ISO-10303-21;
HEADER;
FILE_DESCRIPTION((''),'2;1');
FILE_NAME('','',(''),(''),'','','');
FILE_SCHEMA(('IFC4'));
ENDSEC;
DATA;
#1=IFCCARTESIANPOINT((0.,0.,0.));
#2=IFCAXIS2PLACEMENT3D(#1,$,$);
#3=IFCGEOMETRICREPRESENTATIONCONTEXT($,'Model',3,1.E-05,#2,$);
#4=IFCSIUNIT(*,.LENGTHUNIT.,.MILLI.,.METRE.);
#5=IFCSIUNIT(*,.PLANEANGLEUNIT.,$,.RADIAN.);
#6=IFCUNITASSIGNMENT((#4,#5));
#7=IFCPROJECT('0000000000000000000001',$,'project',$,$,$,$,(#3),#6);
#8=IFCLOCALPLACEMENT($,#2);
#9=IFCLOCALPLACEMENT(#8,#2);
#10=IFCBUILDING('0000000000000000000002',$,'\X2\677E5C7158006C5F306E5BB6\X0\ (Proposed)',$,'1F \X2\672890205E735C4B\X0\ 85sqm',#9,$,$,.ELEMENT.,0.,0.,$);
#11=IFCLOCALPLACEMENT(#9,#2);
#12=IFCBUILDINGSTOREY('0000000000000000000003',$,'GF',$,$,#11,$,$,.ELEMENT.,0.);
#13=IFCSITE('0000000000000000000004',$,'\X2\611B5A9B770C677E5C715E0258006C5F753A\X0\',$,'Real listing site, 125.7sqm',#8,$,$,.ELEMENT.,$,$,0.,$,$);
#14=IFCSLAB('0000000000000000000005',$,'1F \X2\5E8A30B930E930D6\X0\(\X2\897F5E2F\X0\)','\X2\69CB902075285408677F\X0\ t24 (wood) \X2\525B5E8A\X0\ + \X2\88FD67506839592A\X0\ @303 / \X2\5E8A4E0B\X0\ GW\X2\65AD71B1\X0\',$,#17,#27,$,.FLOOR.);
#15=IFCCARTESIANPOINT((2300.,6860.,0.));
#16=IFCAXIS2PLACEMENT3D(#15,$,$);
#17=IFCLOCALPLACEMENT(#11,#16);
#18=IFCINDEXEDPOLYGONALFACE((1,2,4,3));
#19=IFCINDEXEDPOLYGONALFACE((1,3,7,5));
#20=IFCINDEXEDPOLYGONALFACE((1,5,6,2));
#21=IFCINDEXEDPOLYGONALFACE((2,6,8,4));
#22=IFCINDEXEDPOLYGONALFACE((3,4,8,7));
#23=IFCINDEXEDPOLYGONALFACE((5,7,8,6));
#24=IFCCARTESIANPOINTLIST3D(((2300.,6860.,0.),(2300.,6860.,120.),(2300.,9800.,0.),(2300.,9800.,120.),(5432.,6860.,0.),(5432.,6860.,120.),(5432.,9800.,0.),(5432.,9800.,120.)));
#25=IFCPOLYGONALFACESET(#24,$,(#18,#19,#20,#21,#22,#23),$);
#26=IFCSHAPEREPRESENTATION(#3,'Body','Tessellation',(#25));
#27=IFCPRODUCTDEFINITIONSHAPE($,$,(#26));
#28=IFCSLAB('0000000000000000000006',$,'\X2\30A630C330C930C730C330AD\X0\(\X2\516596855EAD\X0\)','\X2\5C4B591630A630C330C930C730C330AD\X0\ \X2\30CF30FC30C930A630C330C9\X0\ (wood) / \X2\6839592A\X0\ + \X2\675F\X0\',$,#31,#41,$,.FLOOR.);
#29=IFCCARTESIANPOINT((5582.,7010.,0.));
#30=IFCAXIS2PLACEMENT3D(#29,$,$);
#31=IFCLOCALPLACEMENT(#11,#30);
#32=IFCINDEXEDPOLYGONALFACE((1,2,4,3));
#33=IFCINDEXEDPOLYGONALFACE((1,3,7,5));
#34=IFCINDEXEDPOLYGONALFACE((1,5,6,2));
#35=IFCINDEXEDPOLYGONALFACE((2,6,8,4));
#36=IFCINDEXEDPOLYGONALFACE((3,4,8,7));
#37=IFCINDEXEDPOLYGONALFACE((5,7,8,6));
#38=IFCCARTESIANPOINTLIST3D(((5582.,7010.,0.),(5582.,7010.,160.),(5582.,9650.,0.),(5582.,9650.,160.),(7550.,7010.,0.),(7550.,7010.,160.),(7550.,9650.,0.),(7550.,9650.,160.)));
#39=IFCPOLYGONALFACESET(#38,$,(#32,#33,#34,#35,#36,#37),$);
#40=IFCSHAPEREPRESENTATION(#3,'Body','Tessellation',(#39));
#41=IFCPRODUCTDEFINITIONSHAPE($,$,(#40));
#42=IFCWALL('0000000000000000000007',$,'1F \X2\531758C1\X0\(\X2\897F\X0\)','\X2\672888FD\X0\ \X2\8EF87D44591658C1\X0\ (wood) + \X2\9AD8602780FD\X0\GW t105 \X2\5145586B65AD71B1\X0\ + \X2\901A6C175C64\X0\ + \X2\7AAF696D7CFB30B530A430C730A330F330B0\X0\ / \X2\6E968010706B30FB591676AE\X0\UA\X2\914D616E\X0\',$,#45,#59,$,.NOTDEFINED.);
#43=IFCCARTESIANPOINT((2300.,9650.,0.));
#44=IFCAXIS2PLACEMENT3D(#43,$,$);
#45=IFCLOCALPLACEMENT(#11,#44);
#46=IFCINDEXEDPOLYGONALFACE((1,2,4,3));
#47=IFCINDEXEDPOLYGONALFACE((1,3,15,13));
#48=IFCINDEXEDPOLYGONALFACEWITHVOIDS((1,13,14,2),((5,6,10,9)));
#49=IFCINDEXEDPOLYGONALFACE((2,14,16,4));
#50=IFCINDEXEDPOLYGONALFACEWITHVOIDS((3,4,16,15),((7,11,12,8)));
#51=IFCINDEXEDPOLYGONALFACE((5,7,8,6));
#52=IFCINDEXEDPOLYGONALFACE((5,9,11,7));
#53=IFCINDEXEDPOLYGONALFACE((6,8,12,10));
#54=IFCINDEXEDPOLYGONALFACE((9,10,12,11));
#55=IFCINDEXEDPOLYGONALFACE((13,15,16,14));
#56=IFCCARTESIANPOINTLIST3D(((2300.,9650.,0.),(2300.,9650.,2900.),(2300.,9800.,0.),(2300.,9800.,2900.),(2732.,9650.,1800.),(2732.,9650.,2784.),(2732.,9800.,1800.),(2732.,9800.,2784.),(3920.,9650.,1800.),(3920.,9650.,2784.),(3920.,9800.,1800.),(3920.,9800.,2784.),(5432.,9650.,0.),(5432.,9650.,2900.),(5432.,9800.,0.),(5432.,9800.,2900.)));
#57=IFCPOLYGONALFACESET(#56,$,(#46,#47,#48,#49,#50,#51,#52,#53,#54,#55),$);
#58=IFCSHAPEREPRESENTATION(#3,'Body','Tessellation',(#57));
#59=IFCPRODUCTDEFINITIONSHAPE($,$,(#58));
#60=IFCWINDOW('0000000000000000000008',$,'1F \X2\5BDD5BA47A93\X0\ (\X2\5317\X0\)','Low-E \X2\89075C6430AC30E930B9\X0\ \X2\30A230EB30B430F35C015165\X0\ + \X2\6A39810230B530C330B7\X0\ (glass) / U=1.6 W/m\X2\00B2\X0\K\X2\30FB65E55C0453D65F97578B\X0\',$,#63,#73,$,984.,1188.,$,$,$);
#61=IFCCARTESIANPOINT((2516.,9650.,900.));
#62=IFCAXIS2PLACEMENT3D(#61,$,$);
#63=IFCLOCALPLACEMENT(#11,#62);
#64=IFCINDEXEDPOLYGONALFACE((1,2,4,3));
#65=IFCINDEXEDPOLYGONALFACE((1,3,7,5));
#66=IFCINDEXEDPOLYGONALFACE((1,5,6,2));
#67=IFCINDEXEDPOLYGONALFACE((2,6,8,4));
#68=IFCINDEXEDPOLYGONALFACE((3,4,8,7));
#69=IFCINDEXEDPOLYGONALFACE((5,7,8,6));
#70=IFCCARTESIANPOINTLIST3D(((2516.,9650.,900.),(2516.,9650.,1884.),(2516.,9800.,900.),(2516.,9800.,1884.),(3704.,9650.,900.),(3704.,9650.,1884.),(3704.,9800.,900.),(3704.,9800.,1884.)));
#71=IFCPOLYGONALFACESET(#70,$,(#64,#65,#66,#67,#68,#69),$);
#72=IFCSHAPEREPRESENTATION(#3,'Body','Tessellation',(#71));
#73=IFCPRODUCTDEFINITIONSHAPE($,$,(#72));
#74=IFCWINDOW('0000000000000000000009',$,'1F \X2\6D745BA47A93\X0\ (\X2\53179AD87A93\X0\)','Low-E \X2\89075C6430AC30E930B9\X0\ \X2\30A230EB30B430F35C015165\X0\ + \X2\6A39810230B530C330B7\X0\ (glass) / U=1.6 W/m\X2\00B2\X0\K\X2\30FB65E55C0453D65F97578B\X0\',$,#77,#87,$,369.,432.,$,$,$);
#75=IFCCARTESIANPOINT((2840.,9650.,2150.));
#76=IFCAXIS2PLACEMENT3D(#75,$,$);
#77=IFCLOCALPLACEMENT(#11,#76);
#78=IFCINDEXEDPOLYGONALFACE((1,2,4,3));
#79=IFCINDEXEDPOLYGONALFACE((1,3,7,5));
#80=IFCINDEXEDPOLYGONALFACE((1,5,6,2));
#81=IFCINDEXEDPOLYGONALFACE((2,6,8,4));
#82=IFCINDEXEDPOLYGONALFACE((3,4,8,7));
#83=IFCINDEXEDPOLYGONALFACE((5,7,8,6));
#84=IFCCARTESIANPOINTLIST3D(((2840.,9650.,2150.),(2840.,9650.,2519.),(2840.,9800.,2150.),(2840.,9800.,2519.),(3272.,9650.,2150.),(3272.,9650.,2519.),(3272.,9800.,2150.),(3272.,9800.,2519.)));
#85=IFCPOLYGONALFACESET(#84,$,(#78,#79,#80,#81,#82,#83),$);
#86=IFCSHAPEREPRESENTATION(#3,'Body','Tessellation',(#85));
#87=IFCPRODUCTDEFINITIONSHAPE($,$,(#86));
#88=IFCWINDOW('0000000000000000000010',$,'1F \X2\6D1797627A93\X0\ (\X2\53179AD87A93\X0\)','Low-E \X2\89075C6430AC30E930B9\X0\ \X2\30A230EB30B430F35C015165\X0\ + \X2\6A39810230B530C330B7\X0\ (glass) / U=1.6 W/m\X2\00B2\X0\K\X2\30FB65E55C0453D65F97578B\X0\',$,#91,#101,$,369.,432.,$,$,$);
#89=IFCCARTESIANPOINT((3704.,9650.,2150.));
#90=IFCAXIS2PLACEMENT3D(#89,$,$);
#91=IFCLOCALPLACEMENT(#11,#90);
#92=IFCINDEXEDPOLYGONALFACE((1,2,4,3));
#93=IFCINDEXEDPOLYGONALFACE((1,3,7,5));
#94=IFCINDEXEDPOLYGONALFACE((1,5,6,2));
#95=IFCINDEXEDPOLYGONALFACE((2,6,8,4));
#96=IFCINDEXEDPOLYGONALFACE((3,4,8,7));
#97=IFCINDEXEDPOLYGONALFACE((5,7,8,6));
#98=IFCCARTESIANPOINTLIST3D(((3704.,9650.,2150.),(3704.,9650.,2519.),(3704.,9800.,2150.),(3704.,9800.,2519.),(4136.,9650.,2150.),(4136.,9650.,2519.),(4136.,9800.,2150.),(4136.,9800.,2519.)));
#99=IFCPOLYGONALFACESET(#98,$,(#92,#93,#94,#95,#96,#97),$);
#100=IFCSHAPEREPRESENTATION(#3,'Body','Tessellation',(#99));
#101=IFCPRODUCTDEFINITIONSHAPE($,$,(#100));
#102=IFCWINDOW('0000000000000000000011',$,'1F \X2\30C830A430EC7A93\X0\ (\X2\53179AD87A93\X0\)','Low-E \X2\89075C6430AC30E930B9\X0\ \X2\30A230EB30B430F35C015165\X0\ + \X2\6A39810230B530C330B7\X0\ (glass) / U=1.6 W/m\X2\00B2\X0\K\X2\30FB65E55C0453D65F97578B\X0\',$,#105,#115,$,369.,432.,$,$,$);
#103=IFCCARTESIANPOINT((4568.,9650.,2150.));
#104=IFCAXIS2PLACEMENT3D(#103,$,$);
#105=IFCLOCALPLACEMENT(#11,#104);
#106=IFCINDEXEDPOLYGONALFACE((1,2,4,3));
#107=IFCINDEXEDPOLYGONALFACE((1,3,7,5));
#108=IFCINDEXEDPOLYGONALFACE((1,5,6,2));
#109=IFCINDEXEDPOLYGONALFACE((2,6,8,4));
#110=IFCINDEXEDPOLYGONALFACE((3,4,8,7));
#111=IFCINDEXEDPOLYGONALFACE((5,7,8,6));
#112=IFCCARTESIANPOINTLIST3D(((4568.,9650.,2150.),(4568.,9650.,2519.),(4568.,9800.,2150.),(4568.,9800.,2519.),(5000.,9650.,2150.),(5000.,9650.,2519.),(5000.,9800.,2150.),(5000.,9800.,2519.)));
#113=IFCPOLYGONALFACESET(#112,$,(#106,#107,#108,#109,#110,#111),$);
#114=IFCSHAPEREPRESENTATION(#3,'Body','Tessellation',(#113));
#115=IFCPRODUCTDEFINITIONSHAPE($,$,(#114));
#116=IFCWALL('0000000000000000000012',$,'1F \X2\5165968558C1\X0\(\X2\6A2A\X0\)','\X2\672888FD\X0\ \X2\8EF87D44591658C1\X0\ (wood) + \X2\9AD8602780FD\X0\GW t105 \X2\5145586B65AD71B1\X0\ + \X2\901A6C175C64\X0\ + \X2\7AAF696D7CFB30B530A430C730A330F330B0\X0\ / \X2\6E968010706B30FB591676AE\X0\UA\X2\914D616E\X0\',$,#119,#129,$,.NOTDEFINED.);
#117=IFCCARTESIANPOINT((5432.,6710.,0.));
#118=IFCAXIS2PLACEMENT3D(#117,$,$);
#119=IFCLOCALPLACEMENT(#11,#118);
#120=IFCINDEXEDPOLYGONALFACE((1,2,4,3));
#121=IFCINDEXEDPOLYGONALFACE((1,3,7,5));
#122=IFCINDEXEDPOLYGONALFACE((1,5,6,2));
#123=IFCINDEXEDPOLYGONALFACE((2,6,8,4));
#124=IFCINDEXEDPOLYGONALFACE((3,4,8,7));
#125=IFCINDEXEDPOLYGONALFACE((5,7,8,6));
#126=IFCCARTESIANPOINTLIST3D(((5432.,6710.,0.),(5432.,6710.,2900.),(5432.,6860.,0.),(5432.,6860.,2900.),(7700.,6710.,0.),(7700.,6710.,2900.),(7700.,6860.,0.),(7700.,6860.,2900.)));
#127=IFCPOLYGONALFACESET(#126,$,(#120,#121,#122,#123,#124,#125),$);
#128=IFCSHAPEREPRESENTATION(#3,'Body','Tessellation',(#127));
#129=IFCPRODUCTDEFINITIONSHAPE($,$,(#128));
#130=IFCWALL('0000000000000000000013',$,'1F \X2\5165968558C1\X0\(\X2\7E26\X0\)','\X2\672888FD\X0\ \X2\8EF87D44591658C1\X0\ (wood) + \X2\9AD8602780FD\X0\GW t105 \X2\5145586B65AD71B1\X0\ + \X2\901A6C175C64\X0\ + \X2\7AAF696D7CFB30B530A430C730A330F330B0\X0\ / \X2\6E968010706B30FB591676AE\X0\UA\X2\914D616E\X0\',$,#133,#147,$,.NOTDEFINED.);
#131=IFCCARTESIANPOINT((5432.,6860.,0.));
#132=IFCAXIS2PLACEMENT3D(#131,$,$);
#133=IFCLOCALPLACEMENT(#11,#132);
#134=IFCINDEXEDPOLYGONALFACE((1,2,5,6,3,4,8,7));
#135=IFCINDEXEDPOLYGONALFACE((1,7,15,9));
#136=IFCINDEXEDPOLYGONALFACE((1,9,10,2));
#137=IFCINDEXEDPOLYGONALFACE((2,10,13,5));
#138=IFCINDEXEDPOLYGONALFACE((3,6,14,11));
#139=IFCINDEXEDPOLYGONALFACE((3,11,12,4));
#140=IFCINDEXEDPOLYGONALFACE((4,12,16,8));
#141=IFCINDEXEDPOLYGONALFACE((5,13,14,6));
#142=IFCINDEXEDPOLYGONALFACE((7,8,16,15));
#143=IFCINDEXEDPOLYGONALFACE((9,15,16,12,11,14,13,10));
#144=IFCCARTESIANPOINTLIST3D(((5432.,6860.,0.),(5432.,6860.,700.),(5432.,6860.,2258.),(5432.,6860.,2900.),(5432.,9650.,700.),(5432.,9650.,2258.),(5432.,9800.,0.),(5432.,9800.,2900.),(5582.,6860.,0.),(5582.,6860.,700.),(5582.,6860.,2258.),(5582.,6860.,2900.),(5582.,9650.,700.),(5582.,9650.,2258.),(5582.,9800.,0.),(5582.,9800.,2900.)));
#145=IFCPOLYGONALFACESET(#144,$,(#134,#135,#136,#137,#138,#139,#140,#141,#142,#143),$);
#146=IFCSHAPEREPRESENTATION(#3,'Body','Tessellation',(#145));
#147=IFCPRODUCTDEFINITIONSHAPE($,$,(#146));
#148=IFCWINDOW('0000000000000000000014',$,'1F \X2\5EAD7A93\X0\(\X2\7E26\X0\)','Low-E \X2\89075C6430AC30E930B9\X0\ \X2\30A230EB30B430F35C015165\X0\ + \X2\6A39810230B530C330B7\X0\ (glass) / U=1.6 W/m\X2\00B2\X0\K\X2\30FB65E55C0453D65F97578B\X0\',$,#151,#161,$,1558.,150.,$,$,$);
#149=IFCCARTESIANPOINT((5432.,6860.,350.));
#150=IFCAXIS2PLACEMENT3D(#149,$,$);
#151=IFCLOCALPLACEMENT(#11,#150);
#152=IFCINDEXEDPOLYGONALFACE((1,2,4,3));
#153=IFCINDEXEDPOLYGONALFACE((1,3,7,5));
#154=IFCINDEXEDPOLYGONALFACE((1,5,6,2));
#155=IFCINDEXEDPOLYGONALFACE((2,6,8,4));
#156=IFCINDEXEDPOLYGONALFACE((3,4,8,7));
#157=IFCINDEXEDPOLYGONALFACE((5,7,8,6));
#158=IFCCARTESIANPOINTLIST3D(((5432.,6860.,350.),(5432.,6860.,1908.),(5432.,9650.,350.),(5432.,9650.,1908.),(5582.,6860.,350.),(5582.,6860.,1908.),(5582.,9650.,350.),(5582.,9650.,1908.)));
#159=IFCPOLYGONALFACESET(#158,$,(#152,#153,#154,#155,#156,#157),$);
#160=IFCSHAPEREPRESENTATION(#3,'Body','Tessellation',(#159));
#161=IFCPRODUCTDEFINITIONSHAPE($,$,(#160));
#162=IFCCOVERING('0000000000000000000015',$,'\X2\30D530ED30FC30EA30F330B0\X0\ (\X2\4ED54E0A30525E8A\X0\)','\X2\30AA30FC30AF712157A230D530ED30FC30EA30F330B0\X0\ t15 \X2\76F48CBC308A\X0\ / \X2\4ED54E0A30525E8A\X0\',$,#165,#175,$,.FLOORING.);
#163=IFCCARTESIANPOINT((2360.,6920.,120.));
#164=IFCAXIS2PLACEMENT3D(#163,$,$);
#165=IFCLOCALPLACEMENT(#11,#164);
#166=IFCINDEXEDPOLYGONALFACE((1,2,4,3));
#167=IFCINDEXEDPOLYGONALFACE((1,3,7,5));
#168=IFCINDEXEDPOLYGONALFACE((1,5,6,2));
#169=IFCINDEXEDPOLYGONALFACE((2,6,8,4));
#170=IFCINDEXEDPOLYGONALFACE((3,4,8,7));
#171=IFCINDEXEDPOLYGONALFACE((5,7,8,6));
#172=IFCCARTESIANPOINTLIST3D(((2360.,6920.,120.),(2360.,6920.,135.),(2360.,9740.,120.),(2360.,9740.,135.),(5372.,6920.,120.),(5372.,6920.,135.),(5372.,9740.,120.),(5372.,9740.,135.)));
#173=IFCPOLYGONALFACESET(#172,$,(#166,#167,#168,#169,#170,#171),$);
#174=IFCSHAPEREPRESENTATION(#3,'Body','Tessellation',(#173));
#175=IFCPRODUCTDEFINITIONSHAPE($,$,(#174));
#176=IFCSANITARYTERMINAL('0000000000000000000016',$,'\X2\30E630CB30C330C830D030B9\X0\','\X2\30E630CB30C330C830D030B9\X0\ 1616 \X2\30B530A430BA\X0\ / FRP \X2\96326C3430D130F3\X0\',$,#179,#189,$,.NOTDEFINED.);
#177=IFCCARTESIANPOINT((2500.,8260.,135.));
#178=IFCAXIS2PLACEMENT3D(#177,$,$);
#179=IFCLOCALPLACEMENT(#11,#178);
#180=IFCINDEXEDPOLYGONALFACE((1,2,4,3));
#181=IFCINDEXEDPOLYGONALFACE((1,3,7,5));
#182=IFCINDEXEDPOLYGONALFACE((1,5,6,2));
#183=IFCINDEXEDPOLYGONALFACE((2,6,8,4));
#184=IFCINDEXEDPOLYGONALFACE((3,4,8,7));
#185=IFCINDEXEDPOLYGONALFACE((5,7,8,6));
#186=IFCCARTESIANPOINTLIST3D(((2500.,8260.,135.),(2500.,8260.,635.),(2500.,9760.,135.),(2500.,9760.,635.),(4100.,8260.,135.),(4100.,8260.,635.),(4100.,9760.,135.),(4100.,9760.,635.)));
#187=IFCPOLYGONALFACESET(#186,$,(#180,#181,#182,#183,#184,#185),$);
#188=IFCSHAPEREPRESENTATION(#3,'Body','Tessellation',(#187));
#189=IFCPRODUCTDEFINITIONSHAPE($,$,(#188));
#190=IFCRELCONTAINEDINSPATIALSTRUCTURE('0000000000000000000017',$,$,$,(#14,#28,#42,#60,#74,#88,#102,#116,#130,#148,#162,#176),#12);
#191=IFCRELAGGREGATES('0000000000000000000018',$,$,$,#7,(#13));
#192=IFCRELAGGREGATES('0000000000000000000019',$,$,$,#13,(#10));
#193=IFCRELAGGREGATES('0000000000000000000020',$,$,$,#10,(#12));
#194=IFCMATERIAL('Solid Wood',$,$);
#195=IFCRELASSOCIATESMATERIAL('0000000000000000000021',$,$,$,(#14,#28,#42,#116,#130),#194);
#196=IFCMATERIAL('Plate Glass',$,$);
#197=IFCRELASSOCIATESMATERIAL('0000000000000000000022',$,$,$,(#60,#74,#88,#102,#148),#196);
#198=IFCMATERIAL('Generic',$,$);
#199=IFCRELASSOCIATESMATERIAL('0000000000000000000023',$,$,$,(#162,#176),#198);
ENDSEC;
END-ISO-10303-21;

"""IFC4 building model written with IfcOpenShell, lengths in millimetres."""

from ifc_helpers import new_model, si_unit, frame, frame_2d, origin, place, context, project, spatial, rectangle, extrude, material, element, fill, save


model = new_model("IFC4")

# Units and contexts
model_context = context("Model", 3, precision=1e-05, world=origin())
ifc_project = project(units=[si_unit("LENGTHUNIT", "METRE", prefix="MILLI"), si_unit("PLANEANGLEUNIT", "RADIAN")], contexts=[model_context])

# Site, building, storey
site_placement = place(None, origin())
site = spatial("IfcSite", under=ifc_project, at=site_placement, Name="愛媛県松山市堀江町", ObjectType="Real listing site, 125.7sqm", CompositionType="ELEMENT", RefElevation=0.0)
building_placement = place(site_placement, origin())
building = spatial("IfcBuilding", under=site, at=building_placement, Name="松山堀江の家 (Proposed)", ObjectType="1F 木造平屋 85sqm", CompositionType="ELEMENT", ElevationOfRefHeight=0.0, ElevationOfTerrain=0.0)
storey_placement = place(building_placement, origin())
storey = spatial("IfcBuildingStorey", under=building, at=storey_placement, Name="GF", CompositionType="ELEMENT", Elevation=0.0)

# Slabs
ifc_material_1 = material(Name="Solid Wood")
slab_1_placement = place(storey_placement, frame((2300.0, 6860.0, 0.0)))
element("IfcSlab", 1, at=slab_1_placement, inside=storey, material=ifc_material_1, Name="1F 床スラブ(西帯)", Description="構造用合板 t24 (wood) 剛床 + 製材根太 @303 / 床下 GW断熱", PredefinedType="FLOOR", context=model_context, shape_type="SweptSolid", body=[
    extrude(rectangle(XDim=3132.0, YDim=2940.0, at=frame_2d((1566.0, 1470.0))), frame((2300.0, 6860.0, 0.0)), (0.0, 0.0, 1.0), 120.0),
])
slab_2_placement = place(storey_placement, frame((5582.0, 7010.0, 0.0)))
element("IfcSlab", 2, at=slab_2_placement, inside=storey, material=ifc_material_1, Name="ウッドデッキ(入隅庭)", Description="屋外ウッドデッキ ハードウッド (wood) / 根太 + 束", PredefinedType="FLOOR", context=model_context, shape_type="SweptSolid", body=[
    extrude(rectangle(XDim=1968.0, YDim=2640.0, at=frame_2d((984.0, 1320.0))), frame((5582.0, 7010.0, 0.0)), (0.0, 0.0, 1.0), 160.0),
])

# Wall, openings, windows
wall_1_placement = place(storey_placement, frame((2300.0, 9650.0, 0.0)))
wall_1 = element("IfcWall", 3, at=wall_1_placement, inside=storey, material=ifc_material_1, Name="1F 北壁(西)", Description="木製 軸組外壁 (wood) + 高性能GW t105 充填断熱 + 通気層 + 窯業系サイディング / 準耐火・外皮UA配慮", PredefinedType="NOTDEFINED", context=model_context, shape_type="SweptSolid", body=[
    extrude(rectangle(XDim=3132.0, YDim=150.0, at=frame_2d((1566.0, 75.0))), frame((2300.0, 9650.0, 0.0)), (0.0, 0.0, 1.0), 2900.0),
])
opening_1_placement = place(storey_placement, frame((2516.0, 9650.0, 900.0)))
opening_1 = element("IfcOpeningElement", 4, at=opening_1_placement, cuts=wall_1, PredefinedType="NOTDEFINED", context=model_context, shape_type="SweptSolid", body=[
    extrude(rectangle(XDim=1188.0, YDim=150.0, at=frame_2d((594.0, 75.0))), frame((2516.0, 9650.0, 900.0)), (0.0, 0.0, 1.0), 984.0),
])
opening_2_placement = place(storey_placement, frame((2840.0, 9650.0, 2150.0)))
opening_2 = element("IfcOpeningElement", 5, at=opening_2_placement, cuts=wall_1, PredefinedType="NOTDEFINED", context=model_context, shape_type="SweptSolid", body=[
    extrude(rectangle(XDim=432.0, YDim=150.0, at=frame_2d((216.0, 75.0))), frame((2840.0, 9650.0, 2150.0)), (0.0, 0.0, 1.0), 369.0),
])
opening_3_placement = place(storey_placement, frame((3704.0, 9650.0, 2150.0)))
opening_3 = element("IfcOpeningElement", 6, at=opening_3_placement, cuts=wall_1, PredefinedType="NOTDEFINED", context=model_context, shape_type="SweptSolid", body=[
    extrude(rectangle(XDim=432.0, YDim=150.0, at=frame_2d((216.0, 75.0))), frame((3704.0, 9650.0, 2150.0)), (0.0, 0.0, 1.0), 369.0),
])
opening_4_placement = place(storey_placement, frame((4568.0, 9650.0, 2150.0)))
opening_4 = element("IfcOpeningElement", 7, at=opening_4_placement, cuts=wall_1, PredefinedType="NOTDEFINED", context=model_context, shape_type="SweptSolid", body=[
    extrude(rectangle(XDim=432.0, YDim=150.0, at=frame_2d((216.0, 75.0))), frame((4568.0, 9650.0, 2150.0)), (0.0, 0.0, 1.0), 369.0),
])
ifc_material_2 = material(Name="Plate Glass")
window_1_placement = place(storey_placement, frame((2516.0, 9650.0, 900.0)))
window_1 = element("IfcWindow", 8, at=window_1_placement, inside=storey, material=ifc_material_2, Name="1F 寝室窓 (北)", Description="Low-E 複層ガラス アルゴン封入 + 樹脂サッシ (glass) / U=1.6 W/m²K・日射取得型", OverallHeight=984.0, OverallWidth=1188.0, context=model_context, shape_type="SweptSolid", body=[
    extrude(rectangle(XDim=1188.0, YDim=150.0, at=frame_2d((594.0, 75.0))), frame((2516.0, 9650.0, 900.0)), (0.0, 0.0, 1.0), 984.0),
])
fill(opening_1, window_1)
window_2_placement = place(storey_placement, frame((2840.0, 9650.0, 2150.0)))
window_2 = element("IfcWindow", 9, at=window_2_placement, inside=storey, material=ifc_material_2, Name="1F 浴室窓 (北高窓)", Description="Low-E 複層ガラス アルゴン封入 + 樹脂サッシ (glass) / U=1.6 W/m²K・日射取得型", OverallHeight=369.0, OverallWidth=432.0, context=model_context, shape_type="SweptSolid", body=[
    extrude(rectangle(XDim=432.0, YDim=150.0, at=frame_2d((216.0, 75.0))), frame((2840.0, 9650.0, 2150.0)), (0.0, 0.0, 1.0), 369.0),
])
fill(opening_2, window_2)
window_3_placement = place(storey_placement, frame((3704.0, 9650.0, 2150.0)))
window_3 = element("IfcWindow", 10, at=window_3_placement, inside=storey, material=ifc_material_2, Name="1F 洗面窓 (北高窓)", Description="Low-E 複層ガラス アルゴン封入 + 樹脂サッシ (glass) / U=1.6 W/m²K・日射取得型", OverallHeight=369.0, OverallWidth=432.0, context=model_context, shape_type="SweptSolid", body=[
    extrude(rectangle(XDim=432.0, YDim=150.0, at=frame_2d((216.0, 75.0))), frame((3704.0, 9650.0, 2150.0)), (0.0, 0.0, 1.0), 369.0),
])
fill(opening_3, window_3)
window_4_placement = place(storey_placement, frame((4568.0, 9650.0, 2150.0)))
window_4 = element("IfcWindow", 11, at=window_4_placement, inside=storey, material=ifc_material_2, Name="1F トイレ窓 (北高窓)", Description="Low-E 複層ガラス アルゴン封入 + 樹脂サッシ (glass) / U=1.6 W/m²K・日射取得型", OverallHeight=369.0, OverallWidth=432.0, context=model_context, shape_type="SweptSolid", body=[
    extrude(rectangle(XDim=432.0, YDim=150.0, at=frame_2d((216.0, 75.0))), frame((4568.0, 9650.0, 2150.0)), (0.0, 0.0, 1.0), 369.0),
])
fill(opening_4, window_4)

# Wall
wall_2_placement = place(storey_placement, frame((5432.0, 6710.0, 0.0)))
element("IfcWall", 12, at=wall_2_placement, inside=storey, material=ifc_material_1, Name="1F 入隅壁(横)", Description="木製 軸組外壁 (wood) + 高性能GW t105 充填断熱 + 通気層 + 窯業系サイディング / 準耐火・外皮UA配慮", PredefinedType="NOTDEFINED", context=model_context, shape_type="SweptSolid", body=[
    extrude(rectangle(XDim=2268.0, YDim=150.0, at=frame_2d((1134.0, 75.0))), frame((5432.0, 6710.0, 0.0)), (0.0, 0.0, 1.0), 2900.0),
])

# Wall, opening, window
wall_3_placement = place(storey_placement, frame((5432.0, 6860.0, 0.0)))
wall_3 = element("IfcWall", 13, at=wall_3_placement, inside=storey, material=ifc_material_1, Name="1F 入隅壁(縦)", Description="木製 軸組外壁 (wood) + 高性能GW t105 充填断熱 + 通気層 + 窯業系サイディング / 準耐火・外皮UA配慮", PredefinedType="NOTDEFINED", context=model_context, shape_type="SweptSolid", body=[
    extrude(rectangle(XDim=150.0, YDim=2940.0, at=frame_2d((75.0, 1470.0))), frame((5432.0, 6860.0, 0.0)), (0.0, 0.0, 1.0), 2900.0),
])
opening_5_placement = place(storey_placement, frame((5432.0, 6860.0, 350.0)))
opening_5 = element("IfcOpeningElement", 14, at=opening_5_placement, cuts=wall_3, PredefinedType="NOTDEFINED", context=model_context, shape_type="SweptSolid", body=[
    extrude(rectangle(XDim=150.0, YDim=2790.0, at=frame_2d((75.0, 1395.0))), frame((5432.0, 6860.0, 350.0)), (0.0, 0.0, 1.0), 1558.0),
])
window_5_placement = place(storey_placement, frame((5432.0, 6860.0, 350.0)))
window_5 = element("IfcWindow", 15, at=window_5_placement, inside=storey, material=ifc_material_2, Name="1F 庭窓(縦)", Description="Low-E 複層ガラス アルゴン封入 + 樹脂サッシ (glass) / U=1.6 W/m²K・日射取得型", OverallHeight=1558.0, OverallWidth=150.0, context=model_context, shape_type="SweptSolid", body=[
    extrude(rectangle(XDim=150.0, YDim=2790.0, at=frame_2d((75.0, 1395.0))), frame((5432.0, 6860.0, 350.0)), (0.0, 0.0, 1.0), 1558.0),
])
fill(opening_5, window_5)

# Covering
ifc_material_3 = material(Name="Generic")
covering_placement = place(storey_placement, frame((2360.0, 6920.0, 120.0)))
element("IfcCovering", 16, at=covering_placement, inside=storey, material=ifc_material_3, Name="フローリング (仕上げ床)", Description="オーク無垢フローリング t15 直貼り / 仕上げ床", PredefinedType="FLOORING", context=model_context, shape_type="SweptSolid", body=[
    extrude(rectangle(XDim=3012.0, YDim=2820.0, at=frame_2d((1506.0, 1410.0))), frame((2360.0, 6920.0, 120.0)), (0.0, 0.0, 1.0), 15.0),
])

# Sanitary terminal
sanitary_terminal_1_placement = place(storey_placement, frame((2500.0, 8260.0, 135.0)))
element("IfcSanitaryTerminal", 17, at=sanitary_terminal_1_placement, inside=storey, material=ifc_material_3, Name="ユニットバス", Description="ユニットバス 1616 サイズ / FRP 防水パン", PredefinedType="NOTDEFINED", context=model_context, shape_type="SweptSolid", body=[
    extrude(rectangle(XDim=1600.0, YDim=1500.0, at=frame_2d((800.0, 750.0))), frame((2500.0, 8260.0, 135.0)), (0.0, 0.0, 1.0), 500.0),
])

save(model, "model.ifc")
